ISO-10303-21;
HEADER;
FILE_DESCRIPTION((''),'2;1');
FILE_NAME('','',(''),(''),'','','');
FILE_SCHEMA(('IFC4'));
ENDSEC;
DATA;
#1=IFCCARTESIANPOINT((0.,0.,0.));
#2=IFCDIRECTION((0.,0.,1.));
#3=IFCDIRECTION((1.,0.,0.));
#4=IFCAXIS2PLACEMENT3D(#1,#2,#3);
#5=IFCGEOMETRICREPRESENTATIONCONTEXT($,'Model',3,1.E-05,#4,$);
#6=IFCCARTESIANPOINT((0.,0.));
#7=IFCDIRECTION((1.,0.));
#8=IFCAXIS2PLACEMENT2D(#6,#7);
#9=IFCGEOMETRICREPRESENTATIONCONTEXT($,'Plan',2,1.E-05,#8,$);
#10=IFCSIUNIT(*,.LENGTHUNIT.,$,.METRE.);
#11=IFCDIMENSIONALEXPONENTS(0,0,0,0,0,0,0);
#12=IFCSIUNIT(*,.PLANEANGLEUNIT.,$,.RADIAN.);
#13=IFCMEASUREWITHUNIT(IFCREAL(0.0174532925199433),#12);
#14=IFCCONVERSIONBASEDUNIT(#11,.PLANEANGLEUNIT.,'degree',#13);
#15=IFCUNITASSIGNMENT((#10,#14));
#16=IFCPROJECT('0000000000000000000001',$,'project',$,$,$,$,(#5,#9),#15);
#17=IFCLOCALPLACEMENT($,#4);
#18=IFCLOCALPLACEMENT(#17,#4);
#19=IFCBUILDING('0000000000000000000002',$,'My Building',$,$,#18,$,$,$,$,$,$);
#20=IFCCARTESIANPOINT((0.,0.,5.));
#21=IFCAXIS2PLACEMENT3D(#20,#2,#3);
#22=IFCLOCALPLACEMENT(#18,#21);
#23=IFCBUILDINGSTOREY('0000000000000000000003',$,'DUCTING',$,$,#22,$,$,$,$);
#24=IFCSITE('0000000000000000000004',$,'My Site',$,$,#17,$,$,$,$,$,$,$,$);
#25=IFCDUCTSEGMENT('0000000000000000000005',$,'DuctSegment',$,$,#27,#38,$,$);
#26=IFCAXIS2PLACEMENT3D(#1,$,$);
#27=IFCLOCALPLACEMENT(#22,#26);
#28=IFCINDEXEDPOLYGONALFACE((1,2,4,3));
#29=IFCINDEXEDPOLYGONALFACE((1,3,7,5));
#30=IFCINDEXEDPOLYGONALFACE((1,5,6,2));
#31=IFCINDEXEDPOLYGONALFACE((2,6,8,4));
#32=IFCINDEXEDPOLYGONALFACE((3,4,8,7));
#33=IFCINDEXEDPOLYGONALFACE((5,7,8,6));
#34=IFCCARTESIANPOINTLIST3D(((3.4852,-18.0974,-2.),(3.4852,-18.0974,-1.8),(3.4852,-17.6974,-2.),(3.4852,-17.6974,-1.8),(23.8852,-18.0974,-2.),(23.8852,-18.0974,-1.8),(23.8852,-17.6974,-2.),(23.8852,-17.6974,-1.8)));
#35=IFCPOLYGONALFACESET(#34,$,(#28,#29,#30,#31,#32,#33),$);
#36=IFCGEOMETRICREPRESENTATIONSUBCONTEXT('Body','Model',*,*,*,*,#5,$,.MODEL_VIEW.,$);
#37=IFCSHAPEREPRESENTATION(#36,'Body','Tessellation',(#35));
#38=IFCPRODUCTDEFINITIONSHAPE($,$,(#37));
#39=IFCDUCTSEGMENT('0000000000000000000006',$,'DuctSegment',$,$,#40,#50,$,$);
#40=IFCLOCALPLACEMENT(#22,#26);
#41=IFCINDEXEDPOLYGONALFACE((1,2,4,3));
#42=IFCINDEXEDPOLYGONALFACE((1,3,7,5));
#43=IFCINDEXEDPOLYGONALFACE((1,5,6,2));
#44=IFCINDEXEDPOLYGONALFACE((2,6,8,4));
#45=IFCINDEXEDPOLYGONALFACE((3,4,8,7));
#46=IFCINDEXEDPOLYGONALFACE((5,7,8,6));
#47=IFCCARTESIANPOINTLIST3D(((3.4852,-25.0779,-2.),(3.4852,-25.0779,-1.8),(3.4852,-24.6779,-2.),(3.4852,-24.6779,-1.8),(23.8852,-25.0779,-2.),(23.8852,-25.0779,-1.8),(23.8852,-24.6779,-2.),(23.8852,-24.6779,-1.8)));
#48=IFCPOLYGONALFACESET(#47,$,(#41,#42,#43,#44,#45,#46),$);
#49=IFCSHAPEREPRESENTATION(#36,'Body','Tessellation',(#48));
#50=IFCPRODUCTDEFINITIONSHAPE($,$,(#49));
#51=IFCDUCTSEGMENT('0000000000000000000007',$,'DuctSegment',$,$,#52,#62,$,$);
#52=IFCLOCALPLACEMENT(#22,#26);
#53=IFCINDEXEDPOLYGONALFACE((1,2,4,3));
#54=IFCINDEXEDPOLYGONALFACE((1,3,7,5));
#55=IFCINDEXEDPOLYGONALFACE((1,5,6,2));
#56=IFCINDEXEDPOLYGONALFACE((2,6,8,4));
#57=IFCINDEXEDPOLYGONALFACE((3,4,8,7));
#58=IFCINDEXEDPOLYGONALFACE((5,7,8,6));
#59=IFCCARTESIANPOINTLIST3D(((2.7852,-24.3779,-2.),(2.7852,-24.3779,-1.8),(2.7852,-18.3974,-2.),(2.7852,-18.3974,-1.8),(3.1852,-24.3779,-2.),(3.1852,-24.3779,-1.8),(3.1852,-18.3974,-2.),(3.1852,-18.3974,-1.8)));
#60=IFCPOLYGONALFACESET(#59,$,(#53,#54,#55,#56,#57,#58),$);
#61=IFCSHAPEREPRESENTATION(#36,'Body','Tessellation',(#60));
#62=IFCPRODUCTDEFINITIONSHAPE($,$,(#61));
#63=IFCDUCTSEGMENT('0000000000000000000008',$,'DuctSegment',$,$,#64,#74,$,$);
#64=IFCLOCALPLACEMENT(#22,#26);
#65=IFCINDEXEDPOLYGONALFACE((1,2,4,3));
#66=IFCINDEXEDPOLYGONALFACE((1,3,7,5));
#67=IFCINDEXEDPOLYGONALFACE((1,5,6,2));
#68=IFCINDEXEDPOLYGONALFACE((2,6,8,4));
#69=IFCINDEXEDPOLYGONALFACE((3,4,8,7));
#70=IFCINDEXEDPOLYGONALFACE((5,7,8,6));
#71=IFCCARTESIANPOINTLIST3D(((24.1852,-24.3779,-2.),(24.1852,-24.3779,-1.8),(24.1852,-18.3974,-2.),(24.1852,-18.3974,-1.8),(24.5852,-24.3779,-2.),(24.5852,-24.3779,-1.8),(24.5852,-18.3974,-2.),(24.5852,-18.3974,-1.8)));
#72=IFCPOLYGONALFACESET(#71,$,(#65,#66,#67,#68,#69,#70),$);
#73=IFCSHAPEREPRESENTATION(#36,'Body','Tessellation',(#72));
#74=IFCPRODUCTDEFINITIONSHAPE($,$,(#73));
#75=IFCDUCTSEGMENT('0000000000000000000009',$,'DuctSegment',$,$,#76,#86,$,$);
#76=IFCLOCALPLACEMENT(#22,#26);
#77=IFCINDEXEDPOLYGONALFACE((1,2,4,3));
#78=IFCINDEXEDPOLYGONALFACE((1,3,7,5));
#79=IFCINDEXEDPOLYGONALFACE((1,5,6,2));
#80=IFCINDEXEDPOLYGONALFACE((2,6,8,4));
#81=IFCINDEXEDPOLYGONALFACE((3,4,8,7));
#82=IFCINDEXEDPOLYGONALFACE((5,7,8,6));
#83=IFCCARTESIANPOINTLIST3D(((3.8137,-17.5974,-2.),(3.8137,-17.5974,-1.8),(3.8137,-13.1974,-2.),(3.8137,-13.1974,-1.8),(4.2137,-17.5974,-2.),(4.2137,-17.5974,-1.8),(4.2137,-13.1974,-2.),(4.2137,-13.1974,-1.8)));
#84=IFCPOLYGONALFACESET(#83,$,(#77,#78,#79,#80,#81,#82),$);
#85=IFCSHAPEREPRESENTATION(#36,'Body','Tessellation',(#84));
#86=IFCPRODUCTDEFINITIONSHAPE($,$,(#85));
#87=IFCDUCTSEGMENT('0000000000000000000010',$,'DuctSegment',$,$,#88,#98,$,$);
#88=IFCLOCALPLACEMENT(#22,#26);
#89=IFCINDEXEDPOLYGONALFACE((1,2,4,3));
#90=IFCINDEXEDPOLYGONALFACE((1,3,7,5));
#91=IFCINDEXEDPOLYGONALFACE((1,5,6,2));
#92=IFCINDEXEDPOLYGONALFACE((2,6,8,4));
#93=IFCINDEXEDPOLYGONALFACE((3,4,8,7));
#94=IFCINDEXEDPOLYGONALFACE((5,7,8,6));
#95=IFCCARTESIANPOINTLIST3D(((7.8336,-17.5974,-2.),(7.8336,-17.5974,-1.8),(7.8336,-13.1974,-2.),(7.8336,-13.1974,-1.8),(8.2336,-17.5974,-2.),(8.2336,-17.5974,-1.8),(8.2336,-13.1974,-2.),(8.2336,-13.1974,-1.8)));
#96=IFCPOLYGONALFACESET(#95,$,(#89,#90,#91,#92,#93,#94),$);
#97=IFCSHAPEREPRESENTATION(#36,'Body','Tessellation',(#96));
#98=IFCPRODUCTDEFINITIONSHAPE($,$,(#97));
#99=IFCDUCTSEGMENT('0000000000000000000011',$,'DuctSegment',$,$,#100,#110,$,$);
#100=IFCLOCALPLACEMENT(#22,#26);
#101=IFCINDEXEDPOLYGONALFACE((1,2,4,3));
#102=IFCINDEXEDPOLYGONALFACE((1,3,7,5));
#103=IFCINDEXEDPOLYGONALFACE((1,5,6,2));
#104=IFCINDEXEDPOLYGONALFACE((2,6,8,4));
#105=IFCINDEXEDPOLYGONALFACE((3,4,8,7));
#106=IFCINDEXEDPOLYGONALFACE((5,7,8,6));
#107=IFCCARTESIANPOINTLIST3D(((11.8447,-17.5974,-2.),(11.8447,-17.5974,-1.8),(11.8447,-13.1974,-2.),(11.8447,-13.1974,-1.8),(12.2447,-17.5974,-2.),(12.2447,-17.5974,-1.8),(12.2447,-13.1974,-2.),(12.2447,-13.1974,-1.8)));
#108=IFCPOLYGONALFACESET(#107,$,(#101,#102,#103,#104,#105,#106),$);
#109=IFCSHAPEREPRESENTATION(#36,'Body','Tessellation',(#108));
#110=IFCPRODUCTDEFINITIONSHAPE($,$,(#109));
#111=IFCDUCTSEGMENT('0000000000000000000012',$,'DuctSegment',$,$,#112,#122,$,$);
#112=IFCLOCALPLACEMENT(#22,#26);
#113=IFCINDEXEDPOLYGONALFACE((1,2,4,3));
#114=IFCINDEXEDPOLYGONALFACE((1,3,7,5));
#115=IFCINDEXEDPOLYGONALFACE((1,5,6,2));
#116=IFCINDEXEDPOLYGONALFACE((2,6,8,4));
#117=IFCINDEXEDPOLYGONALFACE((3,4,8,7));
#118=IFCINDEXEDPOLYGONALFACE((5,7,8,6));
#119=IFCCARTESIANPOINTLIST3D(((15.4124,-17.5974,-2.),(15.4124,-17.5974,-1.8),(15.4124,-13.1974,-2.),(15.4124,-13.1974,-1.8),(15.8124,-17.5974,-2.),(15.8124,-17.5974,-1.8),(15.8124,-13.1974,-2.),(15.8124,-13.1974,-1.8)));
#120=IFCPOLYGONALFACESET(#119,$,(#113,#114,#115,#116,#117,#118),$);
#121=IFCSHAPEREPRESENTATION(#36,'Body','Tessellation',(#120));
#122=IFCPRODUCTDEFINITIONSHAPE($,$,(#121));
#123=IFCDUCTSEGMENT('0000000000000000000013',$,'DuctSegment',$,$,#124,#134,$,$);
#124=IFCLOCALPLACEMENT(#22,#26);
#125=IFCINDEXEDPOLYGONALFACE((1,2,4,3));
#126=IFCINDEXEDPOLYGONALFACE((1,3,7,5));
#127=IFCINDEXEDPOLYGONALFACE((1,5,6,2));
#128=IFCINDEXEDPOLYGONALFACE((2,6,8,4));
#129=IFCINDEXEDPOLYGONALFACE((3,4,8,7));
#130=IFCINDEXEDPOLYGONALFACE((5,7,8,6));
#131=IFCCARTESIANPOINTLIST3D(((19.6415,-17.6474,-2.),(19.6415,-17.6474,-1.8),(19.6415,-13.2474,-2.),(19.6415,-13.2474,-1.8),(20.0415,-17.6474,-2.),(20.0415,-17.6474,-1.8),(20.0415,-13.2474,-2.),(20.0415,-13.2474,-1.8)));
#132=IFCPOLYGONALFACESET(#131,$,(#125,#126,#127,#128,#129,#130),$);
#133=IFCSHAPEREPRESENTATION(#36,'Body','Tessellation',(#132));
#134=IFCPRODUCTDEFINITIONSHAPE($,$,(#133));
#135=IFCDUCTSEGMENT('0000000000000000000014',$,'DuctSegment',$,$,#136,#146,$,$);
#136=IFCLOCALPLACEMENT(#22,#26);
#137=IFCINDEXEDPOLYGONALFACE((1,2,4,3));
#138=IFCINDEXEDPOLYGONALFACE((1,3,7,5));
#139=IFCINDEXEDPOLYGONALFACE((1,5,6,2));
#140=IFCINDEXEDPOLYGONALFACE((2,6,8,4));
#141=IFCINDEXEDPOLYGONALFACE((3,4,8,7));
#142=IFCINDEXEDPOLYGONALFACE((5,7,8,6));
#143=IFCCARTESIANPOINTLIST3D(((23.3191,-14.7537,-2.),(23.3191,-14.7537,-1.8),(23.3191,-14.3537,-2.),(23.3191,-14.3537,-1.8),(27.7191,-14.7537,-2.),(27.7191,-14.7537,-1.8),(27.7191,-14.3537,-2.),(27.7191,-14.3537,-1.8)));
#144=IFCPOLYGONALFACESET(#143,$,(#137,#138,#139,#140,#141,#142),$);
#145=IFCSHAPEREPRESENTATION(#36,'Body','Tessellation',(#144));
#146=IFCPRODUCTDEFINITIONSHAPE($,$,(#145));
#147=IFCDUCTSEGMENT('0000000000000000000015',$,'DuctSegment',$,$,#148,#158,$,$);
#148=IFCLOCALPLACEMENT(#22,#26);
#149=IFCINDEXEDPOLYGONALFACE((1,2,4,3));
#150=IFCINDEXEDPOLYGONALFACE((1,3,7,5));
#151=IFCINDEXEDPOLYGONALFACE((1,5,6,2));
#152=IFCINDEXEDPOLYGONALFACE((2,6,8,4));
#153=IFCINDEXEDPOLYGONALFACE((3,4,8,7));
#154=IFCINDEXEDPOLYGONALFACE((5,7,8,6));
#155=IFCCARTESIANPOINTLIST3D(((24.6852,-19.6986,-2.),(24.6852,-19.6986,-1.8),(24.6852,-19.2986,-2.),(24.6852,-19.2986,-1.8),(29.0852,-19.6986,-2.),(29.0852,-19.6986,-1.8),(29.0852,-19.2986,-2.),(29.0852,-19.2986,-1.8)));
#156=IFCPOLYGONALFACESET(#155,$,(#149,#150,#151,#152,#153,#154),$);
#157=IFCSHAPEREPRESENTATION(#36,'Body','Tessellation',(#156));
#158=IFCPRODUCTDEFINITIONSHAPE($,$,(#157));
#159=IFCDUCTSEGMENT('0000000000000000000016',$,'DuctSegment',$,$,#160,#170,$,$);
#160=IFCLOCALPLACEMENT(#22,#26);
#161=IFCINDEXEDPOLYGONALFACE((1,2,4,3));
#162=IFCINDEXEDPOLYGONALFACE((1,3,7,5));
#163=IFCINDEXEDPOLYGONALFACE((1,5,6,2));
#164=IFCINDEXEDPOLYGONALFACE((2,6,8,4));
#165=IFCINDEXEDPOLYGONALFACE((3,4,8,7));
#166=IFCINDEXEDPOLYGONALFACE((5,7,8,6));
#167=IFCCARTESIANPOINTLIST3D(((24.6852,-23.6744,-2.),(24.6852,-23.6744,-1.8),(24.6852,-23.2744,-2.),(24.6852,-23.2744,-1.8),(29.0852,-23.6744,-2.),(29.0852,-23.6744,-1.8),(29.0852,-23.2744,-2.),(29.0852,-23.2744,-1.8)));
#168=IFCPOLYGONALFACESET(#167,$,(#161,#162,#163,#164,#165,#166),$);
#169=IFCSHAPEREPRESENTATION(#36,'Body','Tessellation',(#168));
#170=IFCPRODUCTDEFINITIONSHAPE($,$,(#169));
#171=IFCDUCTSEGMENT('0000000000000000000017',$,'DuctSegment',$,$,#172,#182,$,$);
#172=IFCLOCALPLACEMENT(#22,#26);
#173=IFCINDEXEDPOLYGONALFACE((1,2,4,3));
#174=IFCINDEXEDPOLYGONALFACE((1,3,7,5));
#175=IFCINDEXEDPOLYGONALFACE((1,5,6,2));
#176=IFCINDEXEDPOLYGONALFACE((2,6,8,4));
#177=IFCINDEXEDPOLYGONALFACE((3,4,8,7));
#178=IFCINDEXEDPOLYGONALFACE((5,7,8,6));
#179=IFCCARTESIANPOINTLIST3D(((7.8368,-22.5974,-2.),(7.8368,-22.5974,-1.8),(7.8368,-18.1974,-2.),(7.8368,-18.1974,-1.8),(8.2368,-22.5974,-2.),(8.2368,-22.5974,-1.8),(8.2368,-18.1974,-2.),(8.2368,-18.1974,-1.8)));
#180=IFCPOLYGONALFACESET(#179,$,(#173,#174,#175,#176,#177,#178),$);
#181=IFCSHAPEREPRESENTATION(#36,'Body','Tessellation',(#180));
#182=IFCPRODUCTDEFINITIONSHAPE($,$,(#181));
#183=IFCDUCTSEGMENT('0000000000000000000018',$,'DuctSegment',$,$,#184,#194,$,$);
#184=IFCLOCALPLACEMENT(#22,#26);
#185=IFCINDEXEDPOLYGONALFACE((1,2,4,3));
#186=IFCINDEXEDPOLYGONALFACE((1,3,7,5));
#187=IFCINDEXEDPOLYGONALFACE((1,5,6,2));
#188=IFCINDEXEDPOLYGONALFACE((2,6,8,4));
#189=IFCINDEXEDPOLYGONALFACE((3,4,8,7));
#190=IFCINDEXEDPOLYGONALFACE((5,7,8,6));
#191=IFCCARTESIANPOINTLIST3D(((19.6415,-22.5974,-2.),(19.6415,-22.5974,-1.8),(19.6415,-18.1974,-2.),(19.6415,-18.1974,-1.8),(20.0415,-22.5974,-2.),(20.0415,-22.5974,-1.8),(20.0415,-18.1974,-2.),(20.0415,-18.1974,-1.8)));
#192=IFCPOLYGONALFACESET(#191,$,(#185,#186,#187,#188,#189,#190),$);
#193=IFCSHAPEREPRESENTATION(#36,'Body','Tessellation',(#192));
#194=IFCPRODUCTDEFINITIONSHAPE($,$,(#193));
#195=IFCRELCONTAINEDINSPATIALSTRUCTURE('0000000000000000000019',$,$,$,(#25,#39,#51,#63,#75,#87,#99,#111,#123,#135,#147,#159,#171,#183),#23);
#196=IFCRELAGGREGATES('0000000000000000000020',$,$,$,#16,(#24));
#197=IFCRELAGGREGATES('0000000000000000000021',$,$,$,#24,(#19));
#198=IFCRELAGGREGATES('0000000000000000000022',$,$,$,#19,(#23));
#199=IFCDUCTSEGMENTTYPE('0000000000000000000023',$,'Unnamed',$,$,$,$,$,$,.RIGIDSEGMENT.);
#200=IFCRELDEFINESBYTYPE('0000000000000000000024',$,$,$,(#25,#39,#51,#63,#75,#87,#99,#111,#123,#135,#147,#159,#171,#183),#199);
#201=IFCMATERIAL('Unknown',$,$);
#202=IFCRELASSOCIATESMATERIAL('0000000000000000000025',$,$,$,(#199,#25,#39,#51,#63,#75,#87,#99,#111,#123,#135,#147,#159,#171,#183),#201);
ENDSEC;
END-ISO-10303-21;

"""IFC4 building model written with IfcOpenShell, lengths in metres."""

from ifc_helpers import new_model, entity, si_unit, converted_unit, frame, origin_with_axes, origin_2d_with_axis, place, context, subcontext, project, spatial, rectangle, extrude, material, material_profile, profile_set, profile_usage, type_object, element, save


model = new_model("IFC4")

# Units and contexts
model_context = context("Model", 3, precision=1e-05, world=origin_with_axes())
plan_context = context("Plan", 2, precision=1e-05, world=origin_2d_with_axis())
body_context = subcontext(model_context, "Body", "Model", "MODEL_VIEW")
ifc_project = project(units=[si_unit("LENGTHUNIT", "METRE"), converted_unit("PLANEANGLEUNIT", "degree", entity("IfcReal", 0.0174532925199433), si_unit("PLANEANGLEUNIT", "RADIAN"), dimensions=[0, 0, 0, 0, 0, 0, 0])], contexts=[model_context, plan_context])

# Site, building, storey
site_placement = place(None, origin_with_axes())
site = spatial("IfcSite", under=ifc_project, at=site_placement, Name="My Site")
building_placement = place(site_placement, origin_with_axes())
building = spatial("IfcBuilding", under=site, at=building_placement, Name="My Building")
storey_placement = place(building_placement, frame((0.0, 0.0, 5.0), z_axis=(0.0, 0.0, 1.0), x_axis=(1.0, 0.0, 0.0)))
storey = spatial("IfcBuildingStorey", under=building, at=storey_placement, Name="DUCTING")

# Duct segments
ifc_material = material(Name="Unknown")
ifc_material_profile = material_profile(ifc_material, rectangle(XDim=0.4, YDim=0.2))
ifc_profile_set = profile_set([ifc_material_profile])
ifc_profile_usage_1 = profile_usage(ifc_profile_set, cardinal=5)
duct_segment_type = type_object("IfcDuctSegmentType", Name="Unnamed", PredefinedType="RIGIDSEGMENT", material=ifc_profile_set)
duct_segment_1_placement = place(storey_placement, frame((3.4852, -17.8974, -1.9), z_axis=(1.0, 0.0, 0.0), x_axis=(0.0, 1.0, 0.0)))
element("IfcDuctSegment", 1, at=duct_segment_1_placement, inside=storey, type_object=duct_segment_type, material=ifc_profile_usage_1, Name="DuctSegment", context=body_context, shape_type="SweptSolid", body=[
    extrude(rectangle(XDim=0.4, YDim=0.2), origin_with_axes(), (0.0, 0.0, 1.0), 20.4),
])
ifc_profile_usage_2 = profile_usage(ifc_profile_set, cardinal=5)
duct_segment_2_placement = place(storey_placement, frame((3.4852, -24.8779, -1.9), z_axis=(1.0, 0.0, 0.0), x_axis=(0.0, 1.0, 0.0)))
element("IfcDuctSegment", 2, at=duct_segment_2_placement, inside=storey, type_object=duct_segment_type, material=ifc_profile_usage_2, Name="DuctSegment", context=body_context, shape_type="SweptSolid", body=[
    extrude(rectangle(XDim=0.4, YDim=0.2), origin_with_axes(), (0.0, 0.0, 1.0), 20.4),
])
ifc_profile_usage_3 = profile_usage(ifc_profile_set, cardinal=5)
duct_segment_3_placement = place(storey_placement, frame((2.9852, -18.3974, -1.9), z_axis=(0.0, -1.0, 0.0), x_axis=(1.0, 0.0, 0.0)))
element("IfcDuctSegment", 3, at=duct_segment_3_placement, inside=storey, type_object=duct_segment_type, material=ifc_profile_usage_3, Name="DuctSegment", context=body_context, shape_type="SweptSolid", body=[
    extrude(rectangle(XDim=0.4, YDim=0.2), origin_with_axes(), (0.0, 0.0, 1.0), 5.9805),
])
ifc_profile_usage_4 = profile_usage(ifc_profile_set, cardinal=5)
duct_segment_4_placement = place(storey_placement, frame((24.3852, -18.3974, -1.9), z_axis=(0.0, -1.0, 0.0), x_axis=(1.0, 0.0, 0.0)))
element("IfcDuctSegment", 4, at=duct_segment_4_placement, inside=storey, type_object=duct_segment_type, material=ifc_profile_usage_4, Name="DuctSegment", context=body_context, shape_type="SweptSolid", body=[
    extrude(rectangle(XDim=0.4, YDim=0.2), origin_with_axes(), (0.0, 0.0, 1.0), 5.9805),
])
ifc_profile_usage_5 = profile_usage(ifc_profile_set, cardinal=5)
duct_segment_5_placement = place(storey_placement, frame((4.0137, -17.5974, -1.9), z_axis=(0.0, 1.0, -0.000003), x_axis=(-1.0, 0.0, 0.0)))
element("IfcDuctSegment", 5, at=duct_segment_5_placement, inside=storey, type_object=duct_segment_type, material=ifc_profile_usage_5, Name="DuctSegment", context=body_context, shape_type="SweptSolid", body=[
    extrude(rectangle(XDim=0.4, YDim=0.2), origin_with_axes(), (0.0, 0.0, 1.0), 4.4),
])
ifc_profile_usage_6 = profile_usage(ifc_profile_set, cardinal=5)
duct_segment_6_placement = place(storey_placement, frame((8.0336, -17.5974, -1.9), z_axis=(0.0, 1.0, -0.000003), x_axis=(-1.0, 0.0, 0.0)))
element("IfcDuctSegment", 6, at=duct_segment_6_placement, inside=storey, type_object=duct_segment_type, material=ifc_profile_usage_6, Name="DuctSegment", context=body_context, shape_type="SweptSolid", body=[
    extrude(rectangle(XDim=0.4, YDim=0.2), origin_with_axes(), (0.0, 0.0, 1.0), 4.4),
])
ifc_profile_usage_7 = profile_usage(ifc_profile_set, cardinal=5)
duct_segment_7_placement = place(storey_placement, frame((12.0447, -17.5974, -1.9), z_axis=(0.0, 1.0, -0.000003), x_axis=(-1.0, 0.0, 0.0)))
element("IfcDuctSegment", 7, at=duct_segment_7_placement, inside=storey, type_object=duct_segment_type, material=ifc_profile_usage_7, Name="DuctSegment", context=body_context, shape_type="SweptSolid", body=[
    extrude(rectangle(XDim=0.4, YDim=0.2), origin_with_axes(), (0.0, 0.0, 1.0), 4.4),
])
ifc_profile_usage_8 = profile_usage(ifc_profile_set, cardinal=5)
duct_segment_8_placement = place(storey_placement, frame((15.6124, -17.5974, -1.9), z_axis=(0.0, 1.0, -0.000003), x_axis=(-1.0, 0.0, 0.0)))
element("IfcDuctSegment", 8, at=duct_segment_8_placement, inside=storey, type_object=duct_segment_type, material=ifc_profile_usage_8, Name="DuctSegment", context=body_context, shape_type="SweptSolid", body=[
    extrude(rectangle(XDim=0.4, YDim=0.2), origin_with_axes(), (0.0, 0.0, 1.0), 4.4),
])
ifc_profile_usage_9 = profile_usage(ifc_profile_set, cardinal=5)
duct_segment_9_placement = place(storey_placement, frame((19.8415, -17.6474, -1.9), z_axis=(0.0, 1.0, -0.000003), x_axis=(-1.0, 0.0, 0.0)))
element("IfcDuctSegment", 9, at=duct_segment_9_placement, inside=storey, type_object=duct_segment_type, material=ifc_profile_usage_9, Name="DuctSegment", context=body_context, shape_type="SweptSolid", body=[
    extrude(rectangle(XDim=0.4, YDim=0.2), origin_with_axes(), (0.0, 0.0, 1.0), 4.4),
])
ifc_profile_usage_10 = profile_usage(ifc_profile_set, cardinal=5)
duct_segment_10_placement = place(storey_placement, frame((27.7191, -14.5537, -1.9), z_axis=(-1.0, 0.0, -0.000003), x_axis=(0.0, -1.0, 0.0)))
element("IfcDuctSegment", 10, at=duct_segment_10_placement, inside=storey, type_object=duct_segment_type, material=ifc_profile_usage_10, Name="DuctSegment", context=body_context, shape_type="SweptSolid", body=[
    extrude(rectangle(XDim=0.4, YDim=0.2), origin_with_axes(), (0.0, 0.0, 1.0), 4.4),
])
ifc_profile_usage_11 = profile_usage(ifc_profile_set, cardinal=5)
duct_segment_11_placement = place(storey_placement, frame((29.0852, -19.4986, -1.9), z_axis=(-1.0, 0.0, -0.000003), x_axis=(0.0, -1.0, 0.0)))
element("IfcDuctSegment", 11, at=duct_segment_11_placement, inside=storey, type_object=duct_segment_type, material=ifc_profile_usage_11, Name="DuctSegment", context=body_context, shape_type="SweptSolid", body=[
    extrude(rectangle(XDim=0.4, YDim=0.2), origin_with_axes(), (0.0, 0.0, 1.0), 4.4),
])
ifc_profile_usage_12 = profile_usage(ifc_profile_set, cardinal=5)
duct_segment_12_placement = place(storey_placement, frame((29.0852, -23.4744, -1.9), z_axis=(-1.0, 0.0, -0.000003), x_axis=(0.0, -1.0, 0.0)))
element("IfcDuctSegment", 12, at=duct_segment_12_placement, inside=storey, type_object=duct_segment_type, material=ifc_profile_usage_12, Name="DuctSegment", context=body_context, shape_type="SweptSolid", body=[
    extrude(rectangle(XDim=0.4, YDim=0.2), origin_with_axes(), (0.0, 0.0, 1.0), 4.4),
])
ifc_profile_usage_13 = profile_usage(ifc_profile_set, cardinal=5)
duct_segment_13_placement = place(storey_placement, frame((8.0368, -22.5974, -1.9), z_axis=(0.0, 1.0, -0.000003), x_axis=(-1.0, 0.0, 0.0)))
element("IfcDuctSegment", 13, at=duct_segment_13_placement, inside=storey, type_object=duct_segment_type, material=ifc_profile_usage_13, Name="DuctSegment", context=body_context, shape_type="SweptSolid", body=[
    extrude(rectangle(XDim=0.4, YDim=0.2), origin_with_axes(), (0.0, 0.0, 1.0), 4.4),
])
ifc_profile_usage_14 = profile_usage(ifc_profile_set, cardinal=5)
duct_segment_14_placement = place(storey_placement, frame((19.8415, -22.5974, -1.9), z_axis=(0.0, 1.0, -0.000003), x_axis=(-1.0, 0.0, 0.0)))
element("IfcDuctSegment", 14, at=duct_segment_14_placement, inside=storey, type_object=duct_segment_type, material=ifc_profile_usage_14, Name="DuctSegment", context=body_context, shape_type="SweptSolid", body=[
    extrude(rectangle(XDim=0.4, YDim=0.2), origin_with_axes(), (0.0, 0.0, 1.0), 4.4),
])

save(model, "model.ifc")
